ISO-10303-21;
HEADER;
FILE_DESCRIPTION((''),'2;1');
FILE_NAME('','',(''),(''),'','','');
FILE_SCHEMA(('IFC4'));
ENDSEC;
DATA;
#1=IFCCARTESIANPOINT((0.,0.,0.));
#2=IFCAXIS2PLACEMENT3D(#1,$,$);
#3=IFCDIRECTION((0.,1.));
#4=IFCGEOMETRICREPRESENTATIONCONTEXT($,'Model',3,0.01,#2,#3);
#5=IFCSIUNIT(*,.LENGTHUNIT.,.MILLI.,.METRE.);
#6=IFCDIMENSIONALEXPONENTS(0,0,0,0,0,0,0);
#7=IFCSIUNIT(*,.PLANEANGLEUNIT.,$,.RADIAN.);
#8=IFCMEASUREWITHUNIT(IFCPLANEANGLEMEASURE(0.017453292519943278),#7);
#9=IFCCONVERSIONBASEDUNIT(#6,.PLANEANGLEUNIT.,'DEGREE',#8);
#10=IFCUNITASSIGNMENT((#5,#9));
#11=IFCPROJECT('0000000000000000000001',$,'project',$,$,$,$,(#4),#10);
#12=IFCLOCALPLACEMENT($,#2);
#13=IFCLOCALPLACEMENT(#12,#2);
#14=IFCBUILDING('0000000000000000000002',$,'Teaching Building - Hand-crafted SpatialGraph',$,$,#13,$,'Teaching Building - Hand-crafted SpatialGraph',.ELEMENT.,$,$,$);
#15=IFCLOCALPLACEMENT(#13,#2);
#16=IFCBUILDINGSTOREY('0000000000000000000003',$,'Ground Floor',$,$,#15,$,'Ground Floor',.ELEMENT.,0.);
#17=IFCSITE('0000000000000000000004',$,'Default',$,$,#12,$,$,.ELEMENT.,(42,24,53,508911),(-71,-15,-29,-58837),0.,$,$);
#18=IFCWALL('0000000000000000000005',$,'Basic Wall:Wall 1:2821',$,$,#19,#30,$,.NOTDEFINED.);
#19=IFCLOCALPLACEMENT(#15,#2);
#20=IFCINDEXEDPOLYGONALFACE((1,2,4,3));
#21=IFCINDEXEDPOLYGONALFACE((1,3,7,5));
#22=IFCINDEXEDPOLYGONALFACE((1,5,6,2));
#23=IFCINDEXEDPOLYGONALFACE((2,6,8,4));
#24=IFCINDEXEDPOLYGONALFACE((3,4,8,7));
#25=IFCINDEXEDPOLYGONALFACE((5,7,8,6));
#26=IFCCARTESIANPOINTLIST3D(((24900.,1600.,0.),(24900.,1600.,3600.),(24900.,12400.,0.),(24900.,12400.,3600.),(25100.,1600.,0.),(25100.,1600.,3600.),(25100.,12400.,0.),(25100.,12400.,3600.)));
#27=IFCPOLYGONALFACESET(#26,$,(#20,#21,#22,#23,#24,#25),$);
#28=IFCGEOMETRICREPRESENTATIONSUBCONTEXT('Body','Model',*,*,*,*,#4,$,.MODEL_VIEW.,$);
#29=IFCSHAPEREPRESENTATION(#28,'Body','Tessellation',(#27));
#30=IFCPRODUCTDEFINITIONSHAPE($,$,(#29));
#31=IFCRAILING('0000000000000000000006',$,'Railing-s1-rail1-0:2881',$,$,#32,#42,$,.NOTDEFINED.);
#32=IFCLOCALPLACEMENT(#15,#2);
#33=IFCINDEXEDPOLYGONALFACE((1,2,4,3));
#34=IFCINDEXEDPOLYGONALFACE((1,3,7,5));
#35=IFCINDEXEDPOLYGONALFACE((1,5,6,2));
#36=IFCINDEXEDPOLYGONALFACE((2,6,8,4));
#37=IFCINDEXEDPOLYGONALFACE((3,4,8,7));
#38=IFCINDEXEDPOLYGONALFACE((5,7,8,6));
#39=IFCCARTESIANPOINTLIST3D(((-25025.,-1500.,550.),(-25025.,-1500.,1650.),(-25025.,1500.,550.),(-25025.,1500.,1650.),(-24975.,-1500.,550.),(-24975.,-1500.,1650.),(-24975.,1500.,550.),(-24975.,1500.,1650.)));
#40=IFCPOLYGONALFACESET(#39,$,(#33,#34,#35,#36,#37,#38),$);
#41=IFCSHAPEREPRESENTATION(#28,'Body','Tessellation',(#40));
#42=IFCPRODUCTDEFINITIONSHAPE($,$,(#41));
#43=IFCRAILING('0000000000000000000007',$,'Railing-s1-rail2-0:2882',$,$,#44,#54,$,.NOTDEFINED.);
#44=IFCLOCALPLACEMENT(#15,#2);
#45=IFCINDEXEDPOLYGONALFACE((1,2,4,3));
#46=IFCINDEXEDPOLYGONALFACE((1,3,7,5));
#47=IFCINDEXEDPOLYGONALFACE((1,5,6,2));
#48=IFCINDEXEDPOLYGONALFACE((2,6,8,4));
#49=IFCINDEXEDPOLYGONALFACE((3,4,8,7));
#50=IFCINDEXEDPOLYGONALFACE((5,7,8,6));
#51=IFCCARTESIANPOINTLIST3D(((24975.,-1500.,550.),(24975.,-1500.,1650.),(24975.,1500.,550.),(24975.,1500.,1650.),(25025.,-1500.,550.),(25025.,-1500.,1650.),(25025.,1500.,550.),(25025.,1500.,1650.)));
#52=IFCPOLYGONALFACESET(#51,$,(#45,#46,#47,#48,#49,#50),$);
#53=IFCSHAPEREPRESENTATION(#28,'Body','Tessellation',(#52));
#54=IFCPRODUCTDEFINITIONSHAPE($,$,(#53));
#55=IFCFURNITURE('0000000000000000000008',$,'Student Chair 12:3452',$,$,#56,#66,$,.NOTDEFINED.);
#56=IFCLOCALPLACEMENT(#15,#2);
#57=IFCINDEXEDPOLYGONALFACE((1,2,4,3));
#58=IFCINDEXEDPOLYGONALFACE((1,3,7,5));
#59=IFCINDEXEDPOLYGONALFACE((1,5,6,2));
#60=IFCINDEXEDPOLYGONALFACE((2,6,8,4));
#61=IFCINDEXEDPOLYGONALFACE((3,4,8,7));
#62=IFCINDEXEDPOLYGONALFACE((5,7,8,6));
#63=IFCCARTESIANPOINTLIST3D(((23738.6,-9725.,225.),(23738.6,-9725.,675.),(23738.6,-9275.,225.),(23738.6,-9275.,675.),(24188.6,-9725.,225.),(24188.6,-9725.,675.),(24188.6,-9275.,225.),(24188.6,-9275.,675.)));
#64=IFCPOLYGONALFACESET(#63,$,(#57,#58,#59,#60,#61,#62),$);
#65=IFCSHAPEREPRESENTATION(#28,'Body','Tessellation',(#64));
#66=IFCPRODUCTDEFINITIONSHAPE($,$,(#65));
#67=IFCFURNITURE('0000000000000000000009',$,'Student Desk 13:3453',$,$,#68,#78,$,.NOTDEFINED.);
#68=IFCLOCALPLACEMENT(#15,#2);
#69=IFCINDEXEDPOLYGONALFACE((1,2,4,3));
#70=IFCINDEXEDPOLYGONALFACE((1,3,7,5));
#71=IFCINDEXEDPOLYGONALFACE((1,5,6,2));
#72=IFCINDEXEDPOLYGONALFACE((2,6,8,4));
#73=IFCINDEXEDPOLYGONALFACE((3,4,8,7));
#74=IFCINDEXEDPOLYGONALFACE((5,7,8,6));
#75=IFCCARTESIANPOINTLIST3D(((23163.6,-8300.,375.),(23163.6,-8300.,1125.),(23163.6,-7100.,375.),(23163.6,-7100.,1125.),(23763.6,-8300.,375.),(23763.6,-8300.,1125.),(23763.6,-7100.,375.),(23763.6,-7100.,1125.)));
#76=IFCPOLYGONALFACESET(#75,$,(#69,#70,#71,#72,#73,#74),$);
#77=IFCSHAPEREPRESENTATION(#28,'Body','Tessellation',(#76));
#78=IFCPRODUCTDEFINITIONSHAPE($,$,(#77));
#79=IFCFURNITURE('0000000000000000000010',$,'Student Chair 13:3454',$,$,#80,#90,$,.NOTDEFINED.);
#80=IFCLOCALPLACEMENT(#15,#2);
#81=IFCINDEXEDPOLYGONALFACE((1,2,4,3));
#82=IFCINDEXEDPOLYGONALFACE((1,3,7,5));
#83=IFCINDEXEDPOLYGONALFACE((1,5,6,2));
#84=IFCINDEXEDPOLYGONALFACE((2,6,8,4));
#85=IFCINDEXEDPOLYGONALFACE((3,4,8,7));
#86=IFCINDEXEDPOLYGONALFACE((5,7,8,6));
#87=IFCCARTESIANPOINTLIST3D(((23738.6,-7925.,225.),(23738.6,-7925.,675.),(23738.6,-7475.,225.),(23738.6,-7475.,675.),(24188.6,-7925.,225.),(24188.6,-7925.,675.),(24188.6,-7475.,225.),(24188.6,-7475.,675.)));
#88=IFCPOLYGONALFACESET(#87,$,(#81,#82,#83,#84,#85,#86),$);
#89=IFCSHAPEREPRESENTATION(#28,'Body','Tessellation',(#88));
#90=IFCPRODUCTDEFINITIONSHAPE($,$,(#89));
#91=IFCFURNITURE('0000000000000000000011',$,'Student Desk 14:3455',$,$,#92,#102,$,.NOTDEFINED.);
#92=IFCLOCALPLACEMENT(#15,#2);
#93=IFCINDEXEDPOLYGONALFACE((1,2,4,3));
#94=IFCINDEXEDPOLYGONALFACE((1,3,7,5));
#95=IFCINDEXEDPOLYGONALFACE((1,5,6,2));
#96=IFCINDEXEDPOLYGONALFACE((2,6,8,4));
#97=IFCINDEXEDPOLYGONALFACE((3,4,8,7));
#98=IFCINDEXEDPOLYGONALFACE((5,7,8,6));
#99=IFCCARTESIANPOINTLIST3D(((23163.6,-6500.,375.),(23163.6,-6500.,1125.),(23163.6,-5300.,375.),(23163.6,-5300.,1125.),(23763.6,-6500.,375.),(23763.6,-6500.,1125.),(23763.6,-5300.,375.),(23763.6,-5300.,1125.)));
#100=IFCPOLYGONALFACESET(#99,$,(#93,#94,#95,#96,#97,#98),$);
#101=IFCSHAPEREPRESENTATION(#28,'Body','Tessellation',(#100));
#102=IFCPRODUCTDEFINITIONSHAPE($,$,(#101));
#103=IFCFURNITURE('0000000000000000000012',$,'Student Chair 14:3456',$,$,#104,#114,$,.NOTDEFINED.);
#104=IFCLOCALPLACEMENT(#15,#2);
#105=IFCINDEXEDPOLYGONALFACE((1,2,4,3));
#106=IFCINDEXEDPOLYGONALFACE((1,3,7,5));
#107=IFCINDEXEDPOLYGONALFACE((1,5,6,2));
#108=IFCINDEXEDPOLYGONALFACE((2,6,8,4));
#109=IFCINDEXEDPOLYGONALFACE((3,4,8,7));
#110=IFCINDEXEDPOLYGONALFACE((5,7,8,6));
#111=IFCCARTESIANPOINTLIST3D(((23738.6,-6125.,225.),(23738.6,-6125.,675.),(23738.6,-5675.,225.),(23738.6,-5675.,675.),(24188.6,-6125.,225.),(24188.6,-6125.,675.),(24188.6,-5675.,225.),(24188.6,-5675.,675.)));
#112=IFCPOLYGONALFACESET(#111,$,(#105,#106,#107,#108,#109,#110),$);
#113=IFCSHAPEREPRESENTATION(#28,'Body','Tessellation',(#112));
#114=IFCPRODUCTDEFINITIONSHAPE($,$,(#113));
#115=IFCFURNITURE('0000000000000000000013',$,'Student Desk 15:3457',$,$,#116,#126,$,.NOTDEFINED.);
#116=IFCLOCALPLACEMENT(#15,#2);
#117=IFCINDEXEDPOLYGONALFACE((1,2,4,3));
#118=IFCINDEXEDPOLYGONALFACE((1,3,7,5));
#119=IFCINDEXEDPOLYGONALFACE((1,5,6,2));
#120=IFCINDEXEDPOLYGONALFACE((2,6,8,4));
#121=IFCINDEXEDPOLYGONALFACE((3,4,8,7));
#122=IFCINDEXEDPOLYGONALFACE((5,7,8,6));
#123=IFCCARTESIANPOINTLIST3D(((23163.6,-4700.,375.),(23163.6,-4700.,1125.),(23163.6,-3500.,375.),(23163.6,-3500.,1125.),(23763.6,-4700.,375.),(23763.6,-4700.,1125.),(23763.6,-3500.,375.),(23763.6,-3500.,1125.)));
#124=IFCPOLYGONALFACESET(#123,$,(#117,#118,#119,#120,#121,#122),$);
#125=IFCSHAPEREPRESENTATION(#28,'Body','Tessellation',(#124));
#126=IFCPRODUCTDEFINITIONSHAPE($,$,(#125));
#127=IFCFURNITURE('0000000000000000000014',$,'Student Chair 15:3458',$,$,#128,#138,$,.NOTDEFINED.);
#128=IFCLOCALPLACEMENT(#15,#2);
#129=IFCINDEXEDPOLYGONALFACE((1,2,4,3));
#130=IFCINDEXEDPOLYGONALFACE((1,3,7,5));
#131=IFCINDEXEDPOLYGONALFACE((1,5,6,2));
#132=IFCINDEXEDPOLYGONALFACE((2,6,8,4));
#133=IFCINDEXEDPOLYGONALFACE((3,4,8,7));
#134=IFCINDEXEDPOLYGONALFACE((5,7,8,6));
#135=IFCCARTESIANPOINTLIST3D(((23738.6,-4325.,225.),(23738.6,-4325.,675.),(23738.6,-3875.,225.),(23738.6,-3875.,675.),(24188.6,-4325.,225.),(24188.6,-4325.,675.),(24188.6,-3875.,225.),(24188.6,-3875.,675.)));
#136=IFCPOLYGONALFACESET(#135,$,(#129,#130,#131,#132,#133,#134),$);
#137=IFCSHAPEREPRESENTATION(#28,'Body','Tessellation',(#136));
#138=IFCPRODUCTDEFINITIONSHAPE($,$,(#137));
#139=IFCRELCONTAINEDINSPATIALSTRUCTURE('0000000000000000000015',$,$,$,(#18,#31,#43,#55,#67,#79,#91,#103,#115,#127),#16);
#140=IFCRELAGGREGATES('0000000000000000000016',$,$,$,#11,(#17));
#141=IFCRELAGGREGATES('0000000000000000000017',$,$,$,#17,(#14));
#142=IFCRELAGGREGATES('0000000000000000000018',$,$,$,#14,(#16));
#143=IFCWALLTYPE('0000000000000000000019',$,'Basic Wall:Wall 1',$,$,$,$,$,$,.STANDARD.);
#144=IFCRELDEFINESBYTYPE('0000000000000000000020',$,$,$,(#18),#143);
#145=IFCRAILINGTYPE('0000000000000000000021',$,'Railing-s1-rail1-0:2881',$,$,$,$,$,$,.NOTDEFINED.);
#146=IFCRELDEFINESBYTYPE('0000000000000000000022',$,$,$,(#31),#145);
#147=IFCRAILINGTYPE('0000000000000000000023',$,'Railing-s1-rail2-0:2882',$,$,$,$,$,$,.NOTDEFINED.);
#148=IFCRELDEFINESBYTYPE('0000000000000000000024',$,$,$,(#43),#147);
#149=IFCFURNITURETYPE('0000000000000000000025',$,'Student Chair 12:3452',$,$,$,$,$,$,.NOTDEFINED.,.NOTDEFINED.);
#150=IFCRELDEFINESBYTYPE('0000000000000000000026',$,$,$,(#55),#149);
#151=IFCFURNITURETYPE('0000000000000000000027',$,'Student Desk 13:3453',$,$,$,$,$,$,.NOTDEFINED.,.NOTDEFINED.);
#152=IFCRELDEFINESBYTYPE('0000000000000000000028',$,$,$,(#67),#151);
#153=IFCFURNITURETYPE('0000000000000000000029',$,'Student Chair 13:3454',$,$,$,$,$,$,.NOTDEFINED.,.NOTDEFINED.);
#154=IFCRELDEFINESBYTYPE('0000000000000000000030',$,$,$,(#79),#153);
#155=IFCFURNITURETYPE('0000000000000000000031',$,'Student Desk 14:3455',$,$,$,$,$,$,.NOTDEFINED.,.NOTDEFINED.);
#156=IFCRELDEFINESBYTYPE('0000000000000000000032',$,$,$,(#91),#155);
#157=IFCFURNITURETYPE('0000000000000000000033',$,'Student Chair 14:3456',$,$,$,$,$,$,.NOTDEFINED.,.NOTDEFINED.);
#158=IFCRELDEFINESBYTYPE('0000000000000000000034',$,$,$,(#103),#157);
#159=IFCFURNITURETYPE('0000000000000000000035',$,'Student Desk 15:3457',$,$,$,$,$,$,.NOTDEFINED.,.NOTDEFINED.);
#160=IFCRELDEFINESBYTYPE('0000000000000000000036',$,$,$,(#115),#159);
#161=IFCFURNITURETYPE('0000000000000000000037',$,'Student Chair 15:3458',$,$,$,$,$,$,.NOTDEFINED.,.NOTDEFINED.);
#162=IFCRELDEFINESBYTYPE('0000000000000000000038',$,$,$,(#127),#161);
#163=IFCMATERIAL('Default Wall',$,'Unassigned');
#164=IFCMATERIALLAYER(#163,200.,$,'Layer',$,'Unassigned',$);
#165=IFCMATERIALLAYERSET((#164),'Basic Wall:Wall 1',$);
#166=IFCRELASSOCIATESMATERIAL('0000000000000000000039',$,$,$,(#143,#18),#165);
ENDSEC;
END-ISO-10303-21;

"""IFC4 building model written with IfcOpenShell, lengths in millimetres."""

from ifc_helpers import new_model, entity, si_unit, converted_unit, direction, frame, frame_2d, origin, origin_2d_with_axis, place, context, subcontext, project, spatial, rectangle, extrude, material, layer, layer_set, layer_usage, type_object, element, save


model = new_model("IFC4")

# Units and contexts
model_context = context("Model", 3, precision=0.01, world=origin(), true_north=direction((0.0, 1.0)))
body_context = subcontext(model_context, "Body", "Model", "MODEL_VIEW")
ifc_project = project(units=[si_unit("LENGTHUNIT", "METRE", prefix="MILLI"), converted_unit("PLANEANGLEUNIT", "DEGREE", entity("IfcPlaneAngleMeasure", 0.017453292519943278), si_unit("PLANEANGLEUNIT", "RADIAN"), dimensions=[0, 0, 0, 0, 0, 0, 0])], contexts=[model_context])

# Site, building, storey
site_placement = place(None, origin())
site = spatial("IfcSite", under=ifc_project, at=site_placement, Name="Default", CompositionType="ELEMENT", RefLatitude=(42, 24, 53, 508911), RefLongitude=(-71, -15, -29, -58837), RefElevation=0.0)
building_placement = place(site_placement, origin())
building = spatial("IfcBuilding", under=site, at=building_placement, Name="Teaching Building - Hand-crafted SpatialGraph", LongName="Teaching Building - Hand-crafted SpatialGraph", CompositionType="ELEMENT")
storey_placement = place(building_placement, origin())
storey = spatial("IfcBuildingStorey", under=building, at=storey_placement, Name="Ground Floor", LongName="Ground Floor", CompositionType="ELEMENT", Elevation=0.0)

# Shared definitions
ifc_material = material(Name="Default Wall", Category="Unassigned")
ifc_layer = layer(ifc_material, 200.0, Name="Layer", Category="Unassigned")
ifc_layer_set = layer_set([ifc_layer], Name="Basic Wall:Wall 1")
wall_type = type_object("IfcWallType", Name="Basic Wall:Wall 1", PredefinedType="STANDARD", material=ifc_layer_set)

# Wall
ifc_layer_usage_1 = layer_usage(ifc_layer_set, "AXIS2", "NEGATIVE", 100.0)
wall_1_placement = place(storey_placement, frame((25000.0, 1600.0, 0.0), z_axis=(0.0, 0.0, 1.0), x_axis=(0.0, 1.0, 0.0)))
element("IfcWall", 1, at=wall_1_placement, inside=storey, type_object=wall_type, material=ifc_layer_usage_1, Name="Basic Wall:Wall 1:2821", PredefinedType="NOTDEFINED", context=body_context, shape_type="SweptSolid", body=[
    extrude(rectangle(XDim=10800.0, YDim=200.0, at=frame_2d((5400.0, 0.0), x_axis=(-1.0, 0.0))), origin(), (0.0, 0.0, 1.0), 3600.0),
])

# Railings
railing_type_1 = type_object("IfcRailingType", Name="Railing-s1-rail1-0:2881", PredefinedType="NOTDEFINED")
railing_1_placement = place(storey_placement, origin())
element("IfcRailing", 2, at=railing_1_placement, inside=storey, type_object=railing_type_1, Name="Railing-s1-rail1-0:2881", PredefinedType="NOTDEFINED", context=body_context, shape_type="SweptSolid", body=[
    extrude(rectangle(XDim=3000.0, YDim=50.0, at=origin_2d_with_axis()), frame((-25000.0, 0.0, 550.0), z_axis=(0.0, 0.0, 1.0), x_axis=(0.0, 1.0, 0.0)), (0.0, 0.0, 1.0), 1100.0),
])
railing_type_2 = type_object("IfcRailingType", Name="Railing-s1-rail2-0:2882", PredefinedType="NOTDEFINED")
railing_2_placement = place(storey_placement, origin())
element("IfcRailing", 3, at=railing_2_placement, inside=storey, type_object=railing_type_2, Name="Railing-s1-rail2-0:2882", PredefinedType="NOTDEFINED", context=body_context, shape_type="SweptSolid", body=[
    extrude(rectangle(XDim=3000.0, YDim=50.0, at=origin_2d_with_axis()), frame((25000.0, 0.0, 550.0), z_axis=(0.0, 0.0, 1.0), x_axis=(0.0, 1.0, 0.0)), (0.0, 0.0, 1.0), 1100.0),
])

# Furniture
furniture_type_1 = type_object("IfcFurnitureType", Name="Student Chair 12:3452", PredefinedType="NOTDEFINED")
furniture_1_placement = place(storey_placement, origin())
element("IfcFurniture", 4, at=furniture_1_placement, inside=storey, type_object=furniture_type_1, Name="Student Chair 12:3452", PredefinedType="NOTDEFINED", context=body_context, shape_type="SweptSolid", body=[
    extrude(rectangle(XDim=450.0, YDim=450.0, at=origin_2d_with_axis()), frame((23963.6, -9500.0, 225.0)), (0.0, 0.0, 1.0), 450.0),
])
furniture_type_2 = type_object("IfcFurnitureType", Name="Student Desk 13:3453", PredefinedType="NOTDEFINED")
furniture_2_placement = place(storey_placement, origin())
element("IfcFurniture", 5, at=furniture_2_placement, inside=storey, type_object=furniture_type_2, Name="Student Desk 13:3453", PredefinedType="NOTDEFINED", context=body_context, shape_type="SweptSolid", body=[
    extrude(rectangle(XDim=1200.0, YDim=600.0, at=origin_2d_with_axis()), frame((23463.6, -7700.0, 375.0), z_axis=(0.0, 0.0, 1.0), x_axis=(0.0, 1.0, 0.0)), (0.0, 0.0, 1.0), 750.0),
])
furniture_type_3 = type_object("IfcFurnitureType", Name="Student Chair 13:3454", PredefinedType="NOTDEFINED")
furniture_3_placement = place(storey_placement, origin())
element("IfcFurniture", 6, at=furniture_3_placement, inside=storey, type_object=furniture_type_3, Name="Student Chair 13:3454", PredefinedType="NOTDEFINED", context=body_context, shape_type="SweptSolid", body=[
    extrude(rectangle(XDim=450.0, YDim=450.0, at=frame_2d((0.0, 0.0), x_axis=(1.0, 0.0))), frame((23963.6, -7700.0, 225.0)), (0.0, 0.0, 1.0), 450.0),
])
furniture_type_4 = type_object("IfcFurnitureType", Name="Student Desk 14:3455", PredefinedType="NOTDEFINED")
furniture_4_placement = place(storey_placement, origin())
element("IfcFurniture", 7, at=furniture_4_placement, inside=storey, type_object=furniture_type_4, Name="Student Desk 14:3455", PredefinedType="NOTDEFINED", context=body_context, shape_type="SweptSolid", body=[
    extrude(rectangle(XDim=1200.0, YDim=600.0, at=origin_2d_with_axis()), frame((23463.6, -5900.0, 375.0), z_axis=(0.0, 0.0, 1.0), x_axis=(0.0, 1.0, 0.0)), (0.0, 0.0, 1.0), 750.0),
])
furniture_type_5 = type_object("IfcFurnitureType", Name="Student Chair 14:3456", PredefinedType="NOTDEFINED")
furniture_5_placement = place(storey_placement, origin())
element("IfcFurniture", 8, at=furniture_5_placement, inside=storey, type_object=furniture_type_5, Name="Student Chair 14:3456", PredefinedType="NOTDEFINED", context=body_context, shape_type="SweptSolid", body=[
    extrude(rectangle(XDim=450.0, YDim=450.0, at=origin_2d_with_axis()), frame((23963.6, -5900.0, 225.0)), (0.0, 0.0, 1.0), 450.0),
])
furniture_type_6 = type_object("IfcFurnitureType", Name="Student Desk 15:3457", PredefinedType="NOTDEFINED")
furniture_6_placement = place(storey_placement, origin())
element("IfcFurniture", 9, at=furniture_6_placement, inside=storey, type_object=furniture_type_6, Name="Student Desk 15:3457", PredefinedType="NOTDEFINED", context=body_context, shape_type="SweptSolid", body=[
    extrude(rectangle(XDim=1200.0, YDim=600.0, at=origin_2d_with_axis()), frame((23463.6, -4100.0, 375.0), z_axis=(0.0, 0.0, 1.0), x_axis=(0.0, 1.0, 0.0)), (0.0, 0.0, 1.0), 750.0),
])
furniture_type_7 = type_object("IfcFurnitureType", Name="Student Chair 15:3458", PredefinedType="NOTDEFINED")
furniture_7_placement = place(storey_placement, origin())
element("IfcFurniture", 10, at=furniture_7_placement, inside=storey, type_object=furniture_type_7, Name="Student Chair 15:3458", PredefinedType="NOTDEFINED", context=body_context, shape_type="SweptSolid", body=[
    extrude(rectangle(XDim=450.0, YDim=450.0, at=origin_2d_with_axis()), frame((23963.6, -4100.0, 225.0)), (0.0, 0.0, 1.0), 450.0),
])

save(model, "model.ifc")
